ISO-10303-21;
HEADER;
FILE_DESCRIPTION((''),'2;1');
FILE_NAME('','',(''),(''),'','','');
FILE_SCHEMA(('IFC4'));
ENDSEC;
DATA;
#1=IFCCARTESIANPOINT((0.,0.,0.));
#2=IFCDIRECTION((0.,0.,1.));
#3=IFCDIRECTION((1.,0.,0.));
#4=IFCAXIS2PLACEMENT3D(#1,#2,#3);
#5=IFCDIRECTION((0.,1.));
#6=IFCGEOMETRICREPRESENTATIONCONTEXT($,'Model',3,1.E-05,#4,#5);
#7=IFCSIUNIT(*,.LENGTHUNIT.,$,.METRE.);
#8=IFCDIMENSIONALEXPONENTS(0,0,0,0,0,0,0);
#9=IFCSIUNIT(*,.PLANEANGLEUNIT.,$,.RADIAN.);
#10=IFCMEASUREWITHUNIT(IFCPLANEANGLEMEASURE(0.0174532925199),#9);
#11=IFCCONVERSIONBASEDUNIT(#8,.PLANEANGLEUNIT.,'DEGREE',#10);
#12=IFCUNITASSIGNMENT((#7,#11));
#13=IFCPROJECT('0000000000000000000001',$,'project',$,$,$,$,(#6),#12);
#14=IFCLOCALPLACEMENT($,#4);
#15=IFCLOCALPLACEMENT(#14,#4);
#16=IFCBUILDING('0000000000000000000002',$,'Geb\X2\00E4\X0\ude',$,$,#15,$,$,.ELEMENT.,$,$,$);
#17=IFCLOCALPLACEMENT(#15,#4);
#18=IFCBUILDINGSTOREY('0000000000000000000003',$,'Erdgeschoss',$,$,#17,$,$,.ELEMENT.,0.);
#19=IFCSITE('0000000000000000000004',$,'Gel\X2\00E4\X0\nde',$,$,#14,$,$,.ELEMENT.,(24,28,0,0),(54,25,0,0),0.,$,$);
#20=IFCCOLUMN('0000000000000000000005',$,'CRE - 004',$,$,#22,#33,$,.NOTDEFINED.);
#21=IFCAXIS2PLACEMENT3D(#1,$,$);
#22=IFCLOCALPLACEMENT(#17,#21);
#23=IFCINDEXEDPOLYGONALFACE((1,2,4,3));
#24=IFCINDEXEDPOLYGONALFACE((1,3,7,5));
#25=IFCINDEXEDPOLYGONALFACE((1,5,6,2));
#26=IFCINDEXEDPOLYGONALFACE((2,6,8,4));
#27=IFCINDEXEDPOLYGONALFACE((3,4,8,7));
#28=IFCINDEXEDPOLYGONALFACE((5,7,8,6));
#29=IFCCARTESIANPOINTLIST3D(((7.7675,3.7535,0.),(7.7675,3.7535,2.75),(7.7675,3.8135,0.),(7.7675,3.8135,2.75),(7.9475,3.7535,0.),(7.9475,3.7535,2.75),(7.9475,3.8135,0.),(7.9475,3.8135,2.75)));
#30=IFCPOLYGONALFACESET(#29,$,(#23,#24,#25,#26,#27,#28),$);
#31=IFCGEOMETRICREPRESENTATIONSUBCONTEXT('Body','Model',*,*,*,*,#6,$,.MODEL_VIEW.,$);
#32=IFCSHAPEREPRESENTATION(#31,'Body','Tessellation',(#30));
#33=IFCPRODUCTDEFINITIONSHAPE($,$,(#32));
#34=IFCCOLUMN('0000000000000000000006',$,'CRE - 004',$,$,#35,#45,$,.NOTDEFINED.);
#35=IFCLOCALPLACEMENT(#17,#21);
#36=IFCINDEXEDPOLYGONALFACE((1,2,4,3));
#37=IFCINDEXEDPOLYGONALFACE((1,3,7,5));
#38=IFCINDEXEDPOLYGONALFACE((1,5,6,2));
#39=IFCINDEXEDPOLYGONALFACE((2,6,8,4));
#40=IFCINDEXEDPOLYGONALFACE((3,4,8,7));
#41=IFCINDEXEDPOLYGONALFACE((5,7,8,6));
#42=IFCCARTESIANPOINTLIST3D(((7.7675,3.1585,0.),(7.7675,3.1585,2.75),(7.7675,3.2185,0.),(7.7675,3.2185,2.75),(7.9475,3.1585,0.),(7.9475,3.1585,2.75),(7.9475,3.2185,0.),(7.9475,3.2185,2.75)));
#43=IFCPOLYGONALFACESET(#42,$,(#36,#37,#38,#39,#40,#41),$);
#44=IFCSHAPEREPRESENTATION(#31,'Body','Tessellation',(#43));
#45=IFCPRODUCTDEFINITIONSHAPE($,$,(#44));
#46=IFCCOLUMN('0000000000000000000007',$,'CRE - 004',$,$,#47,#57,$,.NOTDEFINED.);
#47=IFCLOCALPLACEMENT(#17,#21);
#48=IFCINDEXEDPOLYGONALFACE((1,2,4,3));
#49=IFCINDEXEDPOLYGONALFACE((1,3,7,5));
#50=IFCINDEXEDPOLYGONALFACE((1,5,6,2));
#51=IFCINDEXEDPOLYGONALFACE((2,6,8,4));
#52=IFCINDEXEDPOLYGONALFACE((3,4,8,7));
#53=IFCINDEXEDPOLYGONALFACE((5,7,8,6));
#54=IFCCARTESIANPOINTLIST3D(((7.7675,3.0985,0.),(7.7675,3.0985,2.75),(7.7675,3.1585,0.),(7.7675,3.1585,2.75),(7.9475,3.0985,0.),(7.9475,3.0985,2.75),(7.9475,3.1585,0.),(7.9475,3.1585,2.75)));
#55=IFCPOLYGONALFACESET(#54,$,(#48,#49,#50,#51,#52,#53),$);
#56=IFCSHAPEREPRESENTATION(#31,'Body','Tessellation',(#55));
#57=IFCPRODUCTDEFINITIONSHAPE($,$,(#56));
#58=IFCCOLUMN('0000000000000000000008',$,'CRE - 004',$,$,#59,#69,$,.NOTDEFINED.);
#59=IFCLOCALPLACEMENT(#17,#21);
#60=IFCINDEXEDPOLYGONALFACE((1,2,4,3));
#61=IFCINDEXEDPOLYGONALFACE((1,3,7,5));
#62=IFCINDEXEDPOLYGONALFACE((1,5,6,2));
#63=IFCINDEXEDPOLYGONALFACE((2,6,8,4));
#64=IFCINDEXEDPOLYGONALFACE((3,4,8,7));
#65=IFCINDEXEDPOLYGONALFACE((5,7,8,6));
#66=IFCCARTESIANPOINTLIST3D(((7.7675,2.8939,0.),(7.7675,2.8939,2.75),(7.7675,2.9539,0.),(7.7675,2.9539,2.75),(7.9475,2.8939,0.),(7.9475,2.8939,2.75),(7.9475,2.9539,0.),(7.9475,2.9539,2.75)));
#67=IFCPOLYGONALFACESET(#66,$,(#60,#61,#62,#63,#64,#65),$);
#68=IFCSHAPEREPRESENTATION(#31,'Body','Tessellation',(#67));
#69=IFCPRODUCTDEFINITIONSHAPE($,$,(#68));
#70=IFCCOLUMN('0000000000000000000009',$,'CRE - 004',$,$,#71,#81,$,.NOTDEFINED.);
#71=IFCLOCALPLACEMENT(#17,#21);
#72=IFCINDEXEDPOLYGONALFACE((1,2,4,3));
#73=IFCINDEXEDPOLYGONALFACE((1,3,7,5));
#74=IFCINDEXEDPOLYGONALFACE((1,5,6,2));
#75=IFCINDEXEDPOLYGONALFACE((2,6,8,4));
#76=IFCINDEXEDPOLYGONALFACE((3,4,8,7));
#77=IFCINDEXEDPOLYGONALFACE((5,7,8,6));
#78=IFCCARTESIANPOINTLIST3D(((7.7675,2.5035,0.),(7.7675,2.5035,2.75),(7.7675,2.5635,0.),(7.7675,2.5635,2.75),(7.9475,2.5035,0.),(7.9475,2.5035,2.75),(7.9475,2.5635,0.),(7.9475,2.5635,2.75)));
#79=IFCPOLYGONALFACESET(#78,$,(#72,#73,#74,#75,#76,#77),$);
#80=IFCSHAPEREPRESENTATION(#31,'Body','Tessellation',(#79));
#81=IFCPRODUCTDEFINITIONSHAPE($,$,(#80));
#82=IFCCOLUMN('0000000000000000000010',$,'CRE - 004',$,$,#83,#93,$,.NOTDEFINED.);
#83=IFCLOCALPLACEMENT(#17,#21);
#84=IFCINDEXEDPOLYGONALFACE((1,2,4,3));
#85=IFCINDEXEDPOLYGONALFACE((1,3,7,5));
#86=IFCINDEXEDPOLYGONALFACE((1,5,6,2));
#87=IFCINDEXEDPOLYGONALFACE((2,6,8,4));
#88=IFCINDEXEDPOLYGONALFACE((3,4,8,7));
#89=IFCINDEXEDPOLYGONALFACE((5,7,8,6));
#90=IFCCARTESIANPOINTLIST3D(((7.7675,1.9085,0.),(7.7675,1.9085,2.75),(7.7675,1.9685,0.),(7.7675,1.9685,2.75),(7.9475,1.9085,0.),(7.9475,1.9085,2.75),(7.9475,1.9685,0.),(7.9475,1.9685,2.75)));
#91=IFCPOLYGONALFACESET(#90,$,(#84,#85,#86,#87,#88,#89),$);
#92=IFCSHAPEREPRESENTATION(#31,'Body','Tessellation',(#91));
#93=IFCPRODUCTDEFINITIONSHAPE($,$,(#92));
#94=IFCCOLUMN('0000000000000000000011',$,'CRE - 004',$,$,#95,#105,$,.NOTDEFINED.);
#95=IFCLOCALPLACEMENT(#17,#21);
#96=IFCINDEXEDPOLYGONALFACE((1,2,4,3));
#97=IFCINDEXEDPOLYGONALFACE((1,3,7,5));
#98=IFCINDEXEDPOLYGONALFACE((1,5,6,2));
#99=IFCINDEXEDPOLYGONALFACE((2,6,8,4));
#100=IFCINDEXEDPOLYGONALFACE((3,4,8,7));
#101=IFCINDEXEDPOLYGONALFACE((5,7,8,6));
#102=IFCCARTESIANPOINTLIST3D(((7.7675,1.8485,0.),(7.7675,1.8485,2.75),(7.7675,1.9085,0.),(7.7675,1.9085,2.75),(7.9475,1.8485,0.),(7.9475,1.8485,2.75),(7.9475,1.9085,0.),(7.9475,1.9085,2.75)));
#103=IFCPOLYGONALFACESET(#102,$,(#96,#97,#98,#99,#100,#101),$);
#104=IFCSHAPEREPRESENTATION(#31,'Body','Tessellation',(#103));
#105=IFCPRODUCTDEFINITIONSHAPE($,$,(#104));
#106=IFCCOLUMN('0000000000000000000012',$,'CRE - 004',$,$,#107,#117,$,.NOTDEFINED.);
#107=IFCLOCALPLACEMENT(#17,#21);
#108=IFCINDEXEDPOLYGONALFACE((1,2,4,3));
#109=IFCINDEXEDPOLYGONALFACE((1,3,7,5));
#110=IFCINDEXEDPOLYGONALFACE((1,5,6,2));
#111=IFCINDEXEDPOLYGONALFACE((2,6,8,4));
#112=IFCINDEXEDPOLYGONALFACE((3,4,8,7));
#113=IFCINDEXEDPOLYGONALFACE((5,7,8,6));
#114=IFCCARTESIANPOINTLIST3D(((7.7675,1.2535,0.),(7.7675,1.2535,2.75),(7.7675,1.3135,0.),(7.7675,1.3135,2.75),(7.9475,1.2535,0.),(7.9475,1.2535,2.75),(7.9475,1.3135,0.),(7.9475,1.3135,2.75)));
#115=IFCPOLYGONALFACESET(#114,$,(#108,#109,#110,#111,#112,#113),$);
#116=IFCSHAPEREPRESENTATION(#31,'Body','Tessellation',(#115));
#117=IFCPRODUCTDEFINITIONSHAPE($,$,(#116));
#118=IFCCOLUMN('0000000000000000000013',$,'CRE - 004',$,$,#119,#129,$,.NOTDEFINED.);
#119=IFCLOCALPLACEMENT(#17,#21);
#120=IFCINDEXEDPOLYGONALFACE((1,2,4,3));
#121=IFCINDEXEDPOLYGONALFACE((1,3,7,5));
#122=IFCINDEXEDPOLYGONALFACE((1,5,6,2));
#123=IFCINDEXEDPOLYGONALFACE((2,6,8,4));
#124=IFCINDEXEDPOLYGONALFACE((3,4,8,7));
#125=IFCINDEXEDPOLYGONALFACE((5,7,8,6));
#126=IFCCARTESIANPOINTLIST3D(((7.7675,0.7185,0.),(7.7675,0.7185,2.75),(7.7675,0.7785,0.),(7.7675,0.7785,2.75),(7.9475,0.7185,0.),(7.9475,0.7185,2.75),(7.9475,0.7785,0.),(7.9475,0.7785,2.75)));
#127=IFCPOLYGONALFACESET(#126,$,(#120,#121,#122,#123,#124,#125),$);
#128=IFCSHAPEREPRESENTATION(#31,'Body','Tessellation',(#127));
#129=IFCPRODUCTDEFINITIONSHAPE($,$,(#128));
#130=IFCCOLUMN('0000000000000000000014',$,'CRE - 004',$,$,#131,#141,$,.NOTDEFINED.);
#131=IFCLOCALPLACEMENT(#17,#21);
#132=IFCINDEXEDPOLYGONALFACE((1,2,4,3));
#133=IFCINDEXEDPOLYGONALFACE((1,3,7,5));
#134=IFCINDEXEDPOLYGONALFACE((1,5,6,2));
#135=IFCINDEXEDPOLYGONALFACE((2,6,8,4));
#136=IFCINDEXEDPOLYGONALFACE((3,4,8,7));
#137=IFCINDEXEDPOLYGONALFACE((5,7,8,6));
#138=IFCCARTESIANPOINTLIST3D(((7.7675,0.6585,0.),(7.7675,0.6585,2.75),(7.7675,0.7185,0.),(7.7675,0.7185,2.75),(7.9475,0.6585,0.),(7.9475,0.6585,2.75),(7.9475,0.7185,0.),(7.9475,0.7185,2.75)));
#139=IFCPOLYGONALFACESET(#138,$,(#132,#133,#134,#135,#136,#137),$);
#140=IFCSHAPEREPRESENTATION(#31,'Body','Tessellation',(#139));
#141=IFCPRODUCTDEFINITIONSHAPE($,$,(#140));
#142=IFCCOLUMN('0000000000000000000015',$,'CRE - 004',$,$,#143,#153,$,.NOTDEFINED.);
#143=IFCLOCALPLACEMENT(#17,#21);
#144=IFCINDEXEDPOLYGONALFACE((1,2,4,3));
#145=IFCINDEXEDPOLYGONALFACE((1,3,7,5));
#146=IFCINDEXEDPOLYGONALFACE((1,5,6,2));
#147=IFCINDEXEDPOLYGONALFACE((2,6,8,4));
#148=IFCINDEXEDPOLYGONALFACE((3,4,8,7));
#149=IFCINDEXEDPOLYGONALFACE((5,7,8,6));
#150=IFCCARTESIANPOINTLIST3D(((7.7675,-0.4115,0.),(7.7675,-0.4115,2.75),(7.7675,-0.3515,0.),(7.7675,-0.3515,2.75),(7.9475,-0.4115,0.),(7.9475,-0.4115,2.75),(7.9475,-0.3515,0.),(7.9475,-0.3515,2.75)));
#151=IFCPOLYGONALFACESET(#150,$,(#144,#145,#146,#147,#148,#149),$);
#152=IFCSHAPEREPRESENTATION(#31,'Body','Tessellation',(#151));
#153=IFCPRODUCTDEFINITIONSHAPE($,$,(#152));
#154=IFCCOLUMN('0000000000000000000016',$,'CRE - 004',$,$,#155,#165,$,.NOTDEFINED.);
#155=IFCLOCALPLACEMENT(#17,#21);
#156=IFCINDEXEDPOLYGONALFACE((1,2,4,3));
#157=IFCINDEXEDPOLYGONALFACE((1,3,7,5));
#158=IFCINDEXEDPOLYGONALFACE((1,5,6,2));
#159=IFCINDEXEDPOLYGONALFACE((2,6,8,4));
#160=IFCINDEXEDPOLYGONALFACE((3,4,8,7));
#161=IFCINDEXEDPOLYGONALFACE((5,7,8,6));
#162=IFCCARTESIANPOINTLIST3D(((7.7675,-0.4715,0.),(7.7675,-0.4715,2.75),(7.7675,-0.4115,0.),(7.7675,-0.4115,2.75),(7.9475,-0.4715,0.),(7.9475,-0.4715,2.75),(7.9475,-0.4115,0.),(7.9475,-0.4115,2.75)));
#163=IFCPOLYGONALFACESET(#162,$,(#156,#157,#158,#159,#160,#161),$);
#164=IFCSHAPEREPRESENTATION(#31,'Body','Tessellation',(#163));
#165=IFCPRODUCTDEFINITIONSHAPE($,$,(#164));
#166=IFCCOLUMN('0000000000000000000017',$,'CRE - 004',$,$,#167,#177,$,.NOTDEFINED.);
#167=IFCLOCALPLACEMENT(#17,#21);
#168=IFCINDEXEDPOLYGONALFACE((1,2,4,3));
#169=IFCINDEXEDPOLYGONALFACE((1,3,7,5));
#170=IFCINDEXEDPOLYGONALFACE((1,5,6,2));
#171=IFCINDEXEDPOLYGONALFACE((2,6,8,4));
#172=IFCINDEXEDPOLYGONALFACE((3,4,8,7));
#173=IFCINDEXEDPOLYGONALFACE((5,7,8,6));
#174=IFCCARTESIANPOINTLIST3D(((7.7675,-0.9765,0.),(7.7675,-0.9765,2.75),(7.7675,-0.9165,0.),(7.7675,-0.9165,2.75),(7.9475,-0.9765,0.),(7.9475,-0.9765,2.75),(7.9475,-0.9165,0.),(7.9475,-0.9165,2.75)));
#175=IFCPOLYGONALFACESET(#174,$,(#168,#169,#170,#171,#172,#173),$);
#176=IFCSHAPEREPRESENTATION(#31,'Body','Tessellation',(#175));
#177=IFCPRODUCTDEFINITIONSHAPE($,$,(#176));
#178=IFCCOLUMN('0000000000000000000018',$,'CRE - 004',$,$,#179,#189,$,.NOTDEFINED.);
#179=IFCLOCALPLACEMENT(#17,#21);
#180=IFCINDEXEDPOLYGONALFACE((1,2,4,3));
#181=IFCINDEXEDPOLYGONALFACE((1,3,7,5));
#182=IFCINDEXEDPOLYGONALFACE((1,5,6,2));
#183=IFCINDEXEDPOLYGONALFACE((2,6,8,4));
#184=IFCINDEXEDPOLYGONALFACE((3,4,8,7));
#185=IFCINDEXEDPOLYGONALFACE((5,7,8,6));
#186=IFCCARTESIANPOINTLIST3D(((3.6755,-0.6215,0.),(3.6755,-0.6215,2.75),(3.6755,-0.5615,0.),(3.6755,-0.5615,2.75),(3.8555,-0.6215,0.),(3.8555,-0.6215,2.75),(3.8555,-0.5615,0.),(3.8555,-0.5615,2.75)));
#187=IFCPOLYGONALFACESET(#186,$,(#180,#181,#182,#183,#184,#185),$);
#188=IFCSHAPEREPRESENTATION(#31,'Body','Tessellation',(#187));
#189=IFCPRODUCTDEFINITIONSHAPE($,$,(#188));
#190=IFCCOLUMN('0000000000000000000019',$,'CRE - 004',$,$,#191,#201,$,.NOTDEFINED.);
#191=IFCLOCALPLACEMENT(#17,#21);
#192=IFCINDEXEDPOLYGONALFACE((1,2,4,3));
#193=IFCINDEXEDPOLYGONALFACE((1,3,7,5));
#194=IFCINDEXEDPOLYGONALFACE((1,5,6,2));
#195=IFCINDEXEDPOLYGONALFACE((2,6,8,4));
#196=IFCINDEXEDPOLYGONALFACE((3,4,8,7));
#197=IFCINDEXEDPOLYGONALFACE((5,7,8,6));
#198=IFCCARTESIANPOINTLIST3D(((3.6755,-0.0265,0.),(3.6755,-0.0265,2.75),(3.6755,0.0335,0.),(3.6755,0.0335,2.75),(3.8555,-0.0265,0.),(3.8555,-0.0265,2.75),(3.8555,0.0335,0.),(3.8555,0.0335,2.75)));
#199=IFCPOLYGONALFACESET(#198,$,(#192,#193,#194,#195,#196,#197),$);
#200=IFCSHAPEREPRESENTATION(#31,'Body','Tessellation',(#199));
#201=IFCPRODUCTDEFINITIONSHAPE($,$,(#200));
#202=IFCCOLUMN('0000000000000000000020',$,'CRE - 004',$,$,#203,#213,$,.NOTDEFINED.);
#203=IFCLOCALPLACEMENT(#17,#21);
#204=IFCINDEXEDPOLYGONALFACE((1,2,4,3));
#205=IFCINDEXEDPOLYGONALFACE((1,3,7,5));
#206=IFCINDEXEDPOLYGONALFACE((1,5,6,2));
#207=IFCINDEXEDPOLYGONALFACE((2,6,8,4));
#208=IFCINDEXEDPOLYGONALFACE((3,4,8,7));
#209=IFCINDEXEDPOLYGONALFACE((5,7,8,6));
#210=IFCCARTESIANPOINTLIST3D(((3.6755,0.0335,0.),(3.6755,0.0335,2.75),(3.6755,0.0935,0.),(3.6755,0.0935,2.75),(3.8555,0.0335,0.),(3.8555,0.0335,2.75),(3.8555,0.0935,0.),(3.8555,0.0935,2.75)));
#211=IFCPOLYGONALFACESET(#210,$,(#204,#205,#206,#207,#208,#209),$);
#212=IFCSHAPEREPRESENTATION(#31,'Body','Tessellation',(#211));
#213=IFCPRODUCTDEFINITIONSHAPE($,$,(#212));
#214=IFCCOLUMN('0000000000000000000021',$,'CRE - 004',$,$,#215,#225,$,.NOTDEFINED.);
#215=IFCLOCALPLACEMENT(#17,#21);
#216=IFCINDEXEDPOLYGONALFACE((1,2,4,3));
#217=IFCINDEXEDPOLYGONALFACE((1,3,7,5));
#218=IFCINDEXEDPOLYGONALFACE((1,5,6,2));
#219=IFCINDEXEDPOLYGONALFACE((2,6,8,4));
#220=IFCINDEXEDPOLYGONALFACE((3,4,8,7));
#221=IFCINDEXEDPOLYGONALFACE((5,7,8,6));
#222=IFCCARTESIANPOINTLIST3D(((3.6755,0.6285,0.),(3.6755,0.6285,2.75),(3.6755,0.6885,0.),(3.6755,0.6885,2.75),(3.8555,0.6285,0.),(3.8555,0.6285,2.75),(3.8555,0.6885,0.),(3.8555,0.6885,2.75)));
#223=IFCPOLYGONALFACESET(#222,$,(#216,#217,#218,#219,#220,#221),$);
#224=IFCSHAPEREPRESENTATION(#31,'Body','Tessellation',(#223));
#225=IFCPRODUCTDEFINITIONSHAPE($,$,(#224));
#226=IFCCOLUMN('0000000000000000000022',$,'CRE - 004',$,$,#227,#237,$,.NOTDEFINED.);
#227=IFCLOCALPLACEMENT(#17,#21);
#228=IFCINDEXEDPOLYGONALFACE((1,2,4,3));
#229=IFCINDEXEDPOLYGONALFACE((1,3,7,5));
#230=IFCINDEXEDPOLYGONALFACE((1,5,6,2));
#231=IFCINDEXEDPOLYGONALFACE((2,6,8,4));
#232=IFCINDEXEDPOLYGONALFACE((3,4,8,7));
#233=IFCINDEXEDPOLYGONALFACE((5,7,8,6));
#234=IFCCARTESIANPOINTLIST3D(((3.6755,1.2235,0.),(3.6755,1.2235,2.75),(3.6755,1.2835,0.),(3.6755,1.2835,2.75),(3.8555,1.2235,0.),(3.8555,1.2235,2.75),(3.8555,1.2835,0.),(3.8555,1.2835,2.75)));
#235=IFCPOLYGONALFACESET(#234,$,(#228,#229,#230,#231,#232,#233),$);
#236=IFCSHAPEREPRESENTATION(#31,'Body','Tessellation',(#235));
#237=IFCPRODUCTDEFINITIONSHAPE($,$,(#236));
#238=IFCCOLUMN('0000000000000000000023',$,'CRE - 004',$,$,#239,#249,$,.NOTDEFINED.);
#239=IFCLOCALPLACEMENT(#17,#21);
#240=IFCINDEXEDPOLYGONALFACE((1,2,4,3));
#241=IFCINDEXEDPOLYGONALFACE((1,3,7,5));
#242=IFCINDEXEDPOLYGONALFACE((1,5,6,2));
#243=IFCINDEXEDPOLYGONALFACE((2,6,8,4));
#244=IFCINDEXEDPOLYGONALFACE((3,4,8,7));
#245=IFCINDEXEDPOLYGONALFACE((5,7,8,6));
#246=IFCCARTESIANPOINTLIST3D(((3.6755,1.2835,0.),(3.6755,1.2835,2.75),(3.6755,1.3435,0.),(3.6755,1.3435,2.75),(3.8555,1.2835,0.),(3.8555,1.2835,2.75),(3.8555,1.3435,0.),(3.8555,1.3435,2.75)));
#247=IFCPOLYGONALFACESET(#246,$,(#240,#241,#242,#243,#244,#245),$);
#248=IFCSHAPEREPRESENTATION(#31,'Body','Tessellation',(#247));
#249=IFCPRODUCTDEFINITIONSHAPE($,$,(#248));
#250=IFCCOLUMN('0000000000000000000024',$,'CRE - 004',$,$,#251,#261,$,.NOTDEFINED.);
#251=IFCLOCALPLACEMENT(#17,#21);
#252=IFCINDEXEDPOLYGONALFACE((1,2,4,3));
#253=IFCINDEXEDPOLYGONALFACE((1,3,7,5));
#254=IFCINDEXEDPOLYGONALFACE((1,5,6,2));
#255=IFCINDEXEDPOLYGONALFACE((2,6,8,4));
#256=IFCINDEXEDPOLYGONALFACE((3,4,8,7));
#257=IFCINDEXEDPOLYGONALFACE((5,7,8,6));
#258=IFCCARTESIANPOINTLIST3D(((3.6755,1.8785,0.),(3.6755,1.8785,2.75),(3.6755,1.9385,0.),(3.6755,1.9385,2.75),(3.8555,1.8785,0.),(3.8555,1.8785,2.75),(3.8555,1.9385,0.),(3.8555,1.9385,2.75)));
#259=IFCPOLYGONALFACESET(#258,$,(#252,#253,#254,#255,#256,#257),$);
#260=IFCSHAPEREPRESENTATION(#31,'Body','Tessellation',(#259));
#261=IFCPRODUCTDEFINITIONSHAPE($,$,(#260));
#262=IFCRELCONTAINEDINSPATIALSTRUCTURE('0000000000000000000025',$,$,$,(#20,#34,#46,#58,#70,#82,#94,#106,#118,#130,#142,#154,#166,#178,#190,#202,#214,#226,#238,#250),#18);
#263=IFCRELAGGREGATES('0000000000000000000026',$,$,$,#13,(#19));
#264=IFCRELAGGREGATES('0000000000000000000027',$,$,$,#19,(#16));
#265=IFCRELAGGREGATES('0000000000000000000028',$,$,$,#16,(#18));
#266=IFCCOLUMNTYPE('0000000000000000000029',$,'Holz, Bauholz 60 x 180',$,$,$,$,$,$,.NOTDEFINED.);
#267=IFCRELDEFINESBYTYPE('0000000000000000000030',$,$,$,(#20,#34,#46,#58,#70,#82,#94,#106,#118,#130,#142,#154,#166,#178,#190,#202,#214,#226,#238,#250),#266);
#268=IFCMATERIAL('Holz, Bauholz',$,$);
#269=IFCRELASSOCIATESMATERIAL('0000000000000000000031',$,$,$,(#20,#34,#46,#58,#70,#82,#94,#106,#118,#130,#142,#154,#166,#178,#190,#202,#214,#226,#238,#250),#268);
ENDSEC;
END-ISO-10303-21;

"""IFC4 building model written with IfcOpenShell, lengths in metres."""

from ifc_helpers import new_model, entity, si_unit, converted_unit, direction, frame, origin_with_axes, origin_2d_with_axis, place, context, subcontext, project, spatial, rectangle, extrude, material, type_object, element, save


model = new_model("IFC4")

# Units and contexts
model_context = context("Model", 3, precision=1e-05, world=origin_with_axes(), true_north=direction((0.0, 1.0)))
body_context = subcontext(model_context, "Body", "Model", "MODEL_VIEW")
ifc_project = project(units=[si_unit("LENGTHUNIT", "METRE"), converted_unit("PLANEANGLEUNIT", "DEGREE", entity("IfcPlaneAngleMeasure", 0.0174532925199), si_unit("PLANEANGLEUNIT", "RADIAN"), dimensions=[0, 0, 0, 0, 0, 0, 0])], contexts=[model_context])

# Site, building, storey
site_placement = place(None, origin_with_axes())
site = spatial("IfcSite", under=ifc_project, at=site_placement, Name="Gelände", CompositionType="ELEMENT", RefLatitude=(24, 28, 0, 0), RefLongitude=(54, 25, 0, 0), RefElevation=0.0)
building_placement = place(site_placement, origin_with_axes())
building = spatial("IfcBuilding", under=site, at=building_placement, Name="Gebäude", CompositionType="ELEMENT")
storey_placement = place(building_placement, origin_with_axes())
storey = spatial("IfcBuildingStorey", under=building, at=storey_placement, Name="Erdgeschoss", CompositionType="ELEMENT", Elevation=0.0)

# Columns
ifc_material = material(Name="Holz, Bauholz")
column_type_1 = type_object("IfcColumnType", Name="Holz, Bauholz 60 x 180", PredefinedType="NOTDEFINED")
for number, where, z_axis, x_axis, name in (
    (1, (7.8575, 3.7835, 0.0), (0.0, 0.0, 1.0), (1.0, 0.0, 0.0), "CRE - 004"),
    (2, (7.8575, 3.1885, 0.0), (0.0, 0.0, 1.0), (1.0, 0.0, 0.0), "CRE - 004"),
    (3, (7.8575, 3.1285, 0.0), (0.0, 0.0, 1.0), (1.0, 0.0, 0.0), "CRE - 004"),
    (4, (7.8575, 2.9239, 0.0), (0.0, 0.0, 1.0), (1.0, 0.0, 0.0), "CRE - 004"),
    (5, (7.8575, 2.5335, 0.0), (0.0, 0.0, 1.0), (1.0, 0.0, 0.0), "CRE - 004"),
    (6, (7.8575, 1.9385, 0.0), (0.0, 0.0, 1.0), (1.0, 0.0, 0.0), "CRE - 004"),
    (7, (7.8575, 1.8785, 0.0), (0.0, 0.0, 1.0), (1.0, 0.0, 0.0), "CRE - 004"),
    (8, (7.8575, 1.2835, 0.0), (0.0, 0.0, 1.0), (1.0, 0.0, 0.0), "CRE - 004"),
    (9, (7.8575, 0.7485, 0.0), (0.0, 0.0, 1.0), (1.0, 0.0, 0.0), "CRE - 004"),
    (10, (7.8575, 0.6885, 0.0), (0.0, 0.0, 1.0), (1.0, 0.0, 0.0), "CRE - 004"),
    (11, (7.8575, -0.3815, 0.0), (0.0, 0.0, 1.0), (1.0, 0.0, 0.0), "CRE - 004"),
    (12, (7.8575, -0.4415, 0.0), (0.0, 0.0, 1.0), (1.0, 0.0, 0.0), "CRE - 004"),
    (13, (7.8575, -0.9465, 0.0), (0.0, 0.0, 1.0), (1.0, 0.0, 0.0), "CRE - 004"),
    (14, (3.7655, -0.5915, 0.0), (0.0, 0.0, 1.0), (1.0, 0.0, 0.0), "CRE - 004"),
    (15, (3.7655, 0.0035, 0.0), (0.0, 0.0, 1.0), (1.0, 0.0, 0.0), "CRE - 004"),
    (16, (3.7655, 0.0635, 0.0), (0.0, 0.0, 1.0), (1.0, 0.0, 0.0), "CRE - 004"),
    (17, (3.7655, 0.6585, 0.0), (0.0, 0.0, 1.0), (1.0, 0.0, 0.0), "CRE - 004"),
    (18, (3.7655, 1.2535, 0.0), (0.0, 0.0, 1.0), (1.0, 0.0, 0.0), "CRE - 004"),
    (19, (3.7655, 1.3135, 0.0), (0.0, 0.0, 1.0), (1.0, 0.0, 0.0), "CRE - 004"),
    (20, (3.7655, 1.9085, 0.0), (0.0, 0.0, 1.0), (1.0, 0.0, 0.0), "CRE - 004"),
):
    element("IfcColumn", number, at=place(storey_placement, frame(where, z_axis=z_axis, x_axis=x_axis)), inside=storey, type_object=column_type_1, material=ifc_material, Name=name, PredefinedType="NOTDEFINED", context=body_context, shape_type="SweptSolid", body=[
        extrude(rectangle(XDim=0.06, YDim=0.18, at=origin_2d_with_axis()), frame((0.0, 0.0, 0.0), z_axis=(0.0, 0.0, 1.0), x_axis=(0.0, 1.0, 0.0)), (0.0, 0.0, 1.0), 2.75),
    ])

save(model, "model.ifc")
